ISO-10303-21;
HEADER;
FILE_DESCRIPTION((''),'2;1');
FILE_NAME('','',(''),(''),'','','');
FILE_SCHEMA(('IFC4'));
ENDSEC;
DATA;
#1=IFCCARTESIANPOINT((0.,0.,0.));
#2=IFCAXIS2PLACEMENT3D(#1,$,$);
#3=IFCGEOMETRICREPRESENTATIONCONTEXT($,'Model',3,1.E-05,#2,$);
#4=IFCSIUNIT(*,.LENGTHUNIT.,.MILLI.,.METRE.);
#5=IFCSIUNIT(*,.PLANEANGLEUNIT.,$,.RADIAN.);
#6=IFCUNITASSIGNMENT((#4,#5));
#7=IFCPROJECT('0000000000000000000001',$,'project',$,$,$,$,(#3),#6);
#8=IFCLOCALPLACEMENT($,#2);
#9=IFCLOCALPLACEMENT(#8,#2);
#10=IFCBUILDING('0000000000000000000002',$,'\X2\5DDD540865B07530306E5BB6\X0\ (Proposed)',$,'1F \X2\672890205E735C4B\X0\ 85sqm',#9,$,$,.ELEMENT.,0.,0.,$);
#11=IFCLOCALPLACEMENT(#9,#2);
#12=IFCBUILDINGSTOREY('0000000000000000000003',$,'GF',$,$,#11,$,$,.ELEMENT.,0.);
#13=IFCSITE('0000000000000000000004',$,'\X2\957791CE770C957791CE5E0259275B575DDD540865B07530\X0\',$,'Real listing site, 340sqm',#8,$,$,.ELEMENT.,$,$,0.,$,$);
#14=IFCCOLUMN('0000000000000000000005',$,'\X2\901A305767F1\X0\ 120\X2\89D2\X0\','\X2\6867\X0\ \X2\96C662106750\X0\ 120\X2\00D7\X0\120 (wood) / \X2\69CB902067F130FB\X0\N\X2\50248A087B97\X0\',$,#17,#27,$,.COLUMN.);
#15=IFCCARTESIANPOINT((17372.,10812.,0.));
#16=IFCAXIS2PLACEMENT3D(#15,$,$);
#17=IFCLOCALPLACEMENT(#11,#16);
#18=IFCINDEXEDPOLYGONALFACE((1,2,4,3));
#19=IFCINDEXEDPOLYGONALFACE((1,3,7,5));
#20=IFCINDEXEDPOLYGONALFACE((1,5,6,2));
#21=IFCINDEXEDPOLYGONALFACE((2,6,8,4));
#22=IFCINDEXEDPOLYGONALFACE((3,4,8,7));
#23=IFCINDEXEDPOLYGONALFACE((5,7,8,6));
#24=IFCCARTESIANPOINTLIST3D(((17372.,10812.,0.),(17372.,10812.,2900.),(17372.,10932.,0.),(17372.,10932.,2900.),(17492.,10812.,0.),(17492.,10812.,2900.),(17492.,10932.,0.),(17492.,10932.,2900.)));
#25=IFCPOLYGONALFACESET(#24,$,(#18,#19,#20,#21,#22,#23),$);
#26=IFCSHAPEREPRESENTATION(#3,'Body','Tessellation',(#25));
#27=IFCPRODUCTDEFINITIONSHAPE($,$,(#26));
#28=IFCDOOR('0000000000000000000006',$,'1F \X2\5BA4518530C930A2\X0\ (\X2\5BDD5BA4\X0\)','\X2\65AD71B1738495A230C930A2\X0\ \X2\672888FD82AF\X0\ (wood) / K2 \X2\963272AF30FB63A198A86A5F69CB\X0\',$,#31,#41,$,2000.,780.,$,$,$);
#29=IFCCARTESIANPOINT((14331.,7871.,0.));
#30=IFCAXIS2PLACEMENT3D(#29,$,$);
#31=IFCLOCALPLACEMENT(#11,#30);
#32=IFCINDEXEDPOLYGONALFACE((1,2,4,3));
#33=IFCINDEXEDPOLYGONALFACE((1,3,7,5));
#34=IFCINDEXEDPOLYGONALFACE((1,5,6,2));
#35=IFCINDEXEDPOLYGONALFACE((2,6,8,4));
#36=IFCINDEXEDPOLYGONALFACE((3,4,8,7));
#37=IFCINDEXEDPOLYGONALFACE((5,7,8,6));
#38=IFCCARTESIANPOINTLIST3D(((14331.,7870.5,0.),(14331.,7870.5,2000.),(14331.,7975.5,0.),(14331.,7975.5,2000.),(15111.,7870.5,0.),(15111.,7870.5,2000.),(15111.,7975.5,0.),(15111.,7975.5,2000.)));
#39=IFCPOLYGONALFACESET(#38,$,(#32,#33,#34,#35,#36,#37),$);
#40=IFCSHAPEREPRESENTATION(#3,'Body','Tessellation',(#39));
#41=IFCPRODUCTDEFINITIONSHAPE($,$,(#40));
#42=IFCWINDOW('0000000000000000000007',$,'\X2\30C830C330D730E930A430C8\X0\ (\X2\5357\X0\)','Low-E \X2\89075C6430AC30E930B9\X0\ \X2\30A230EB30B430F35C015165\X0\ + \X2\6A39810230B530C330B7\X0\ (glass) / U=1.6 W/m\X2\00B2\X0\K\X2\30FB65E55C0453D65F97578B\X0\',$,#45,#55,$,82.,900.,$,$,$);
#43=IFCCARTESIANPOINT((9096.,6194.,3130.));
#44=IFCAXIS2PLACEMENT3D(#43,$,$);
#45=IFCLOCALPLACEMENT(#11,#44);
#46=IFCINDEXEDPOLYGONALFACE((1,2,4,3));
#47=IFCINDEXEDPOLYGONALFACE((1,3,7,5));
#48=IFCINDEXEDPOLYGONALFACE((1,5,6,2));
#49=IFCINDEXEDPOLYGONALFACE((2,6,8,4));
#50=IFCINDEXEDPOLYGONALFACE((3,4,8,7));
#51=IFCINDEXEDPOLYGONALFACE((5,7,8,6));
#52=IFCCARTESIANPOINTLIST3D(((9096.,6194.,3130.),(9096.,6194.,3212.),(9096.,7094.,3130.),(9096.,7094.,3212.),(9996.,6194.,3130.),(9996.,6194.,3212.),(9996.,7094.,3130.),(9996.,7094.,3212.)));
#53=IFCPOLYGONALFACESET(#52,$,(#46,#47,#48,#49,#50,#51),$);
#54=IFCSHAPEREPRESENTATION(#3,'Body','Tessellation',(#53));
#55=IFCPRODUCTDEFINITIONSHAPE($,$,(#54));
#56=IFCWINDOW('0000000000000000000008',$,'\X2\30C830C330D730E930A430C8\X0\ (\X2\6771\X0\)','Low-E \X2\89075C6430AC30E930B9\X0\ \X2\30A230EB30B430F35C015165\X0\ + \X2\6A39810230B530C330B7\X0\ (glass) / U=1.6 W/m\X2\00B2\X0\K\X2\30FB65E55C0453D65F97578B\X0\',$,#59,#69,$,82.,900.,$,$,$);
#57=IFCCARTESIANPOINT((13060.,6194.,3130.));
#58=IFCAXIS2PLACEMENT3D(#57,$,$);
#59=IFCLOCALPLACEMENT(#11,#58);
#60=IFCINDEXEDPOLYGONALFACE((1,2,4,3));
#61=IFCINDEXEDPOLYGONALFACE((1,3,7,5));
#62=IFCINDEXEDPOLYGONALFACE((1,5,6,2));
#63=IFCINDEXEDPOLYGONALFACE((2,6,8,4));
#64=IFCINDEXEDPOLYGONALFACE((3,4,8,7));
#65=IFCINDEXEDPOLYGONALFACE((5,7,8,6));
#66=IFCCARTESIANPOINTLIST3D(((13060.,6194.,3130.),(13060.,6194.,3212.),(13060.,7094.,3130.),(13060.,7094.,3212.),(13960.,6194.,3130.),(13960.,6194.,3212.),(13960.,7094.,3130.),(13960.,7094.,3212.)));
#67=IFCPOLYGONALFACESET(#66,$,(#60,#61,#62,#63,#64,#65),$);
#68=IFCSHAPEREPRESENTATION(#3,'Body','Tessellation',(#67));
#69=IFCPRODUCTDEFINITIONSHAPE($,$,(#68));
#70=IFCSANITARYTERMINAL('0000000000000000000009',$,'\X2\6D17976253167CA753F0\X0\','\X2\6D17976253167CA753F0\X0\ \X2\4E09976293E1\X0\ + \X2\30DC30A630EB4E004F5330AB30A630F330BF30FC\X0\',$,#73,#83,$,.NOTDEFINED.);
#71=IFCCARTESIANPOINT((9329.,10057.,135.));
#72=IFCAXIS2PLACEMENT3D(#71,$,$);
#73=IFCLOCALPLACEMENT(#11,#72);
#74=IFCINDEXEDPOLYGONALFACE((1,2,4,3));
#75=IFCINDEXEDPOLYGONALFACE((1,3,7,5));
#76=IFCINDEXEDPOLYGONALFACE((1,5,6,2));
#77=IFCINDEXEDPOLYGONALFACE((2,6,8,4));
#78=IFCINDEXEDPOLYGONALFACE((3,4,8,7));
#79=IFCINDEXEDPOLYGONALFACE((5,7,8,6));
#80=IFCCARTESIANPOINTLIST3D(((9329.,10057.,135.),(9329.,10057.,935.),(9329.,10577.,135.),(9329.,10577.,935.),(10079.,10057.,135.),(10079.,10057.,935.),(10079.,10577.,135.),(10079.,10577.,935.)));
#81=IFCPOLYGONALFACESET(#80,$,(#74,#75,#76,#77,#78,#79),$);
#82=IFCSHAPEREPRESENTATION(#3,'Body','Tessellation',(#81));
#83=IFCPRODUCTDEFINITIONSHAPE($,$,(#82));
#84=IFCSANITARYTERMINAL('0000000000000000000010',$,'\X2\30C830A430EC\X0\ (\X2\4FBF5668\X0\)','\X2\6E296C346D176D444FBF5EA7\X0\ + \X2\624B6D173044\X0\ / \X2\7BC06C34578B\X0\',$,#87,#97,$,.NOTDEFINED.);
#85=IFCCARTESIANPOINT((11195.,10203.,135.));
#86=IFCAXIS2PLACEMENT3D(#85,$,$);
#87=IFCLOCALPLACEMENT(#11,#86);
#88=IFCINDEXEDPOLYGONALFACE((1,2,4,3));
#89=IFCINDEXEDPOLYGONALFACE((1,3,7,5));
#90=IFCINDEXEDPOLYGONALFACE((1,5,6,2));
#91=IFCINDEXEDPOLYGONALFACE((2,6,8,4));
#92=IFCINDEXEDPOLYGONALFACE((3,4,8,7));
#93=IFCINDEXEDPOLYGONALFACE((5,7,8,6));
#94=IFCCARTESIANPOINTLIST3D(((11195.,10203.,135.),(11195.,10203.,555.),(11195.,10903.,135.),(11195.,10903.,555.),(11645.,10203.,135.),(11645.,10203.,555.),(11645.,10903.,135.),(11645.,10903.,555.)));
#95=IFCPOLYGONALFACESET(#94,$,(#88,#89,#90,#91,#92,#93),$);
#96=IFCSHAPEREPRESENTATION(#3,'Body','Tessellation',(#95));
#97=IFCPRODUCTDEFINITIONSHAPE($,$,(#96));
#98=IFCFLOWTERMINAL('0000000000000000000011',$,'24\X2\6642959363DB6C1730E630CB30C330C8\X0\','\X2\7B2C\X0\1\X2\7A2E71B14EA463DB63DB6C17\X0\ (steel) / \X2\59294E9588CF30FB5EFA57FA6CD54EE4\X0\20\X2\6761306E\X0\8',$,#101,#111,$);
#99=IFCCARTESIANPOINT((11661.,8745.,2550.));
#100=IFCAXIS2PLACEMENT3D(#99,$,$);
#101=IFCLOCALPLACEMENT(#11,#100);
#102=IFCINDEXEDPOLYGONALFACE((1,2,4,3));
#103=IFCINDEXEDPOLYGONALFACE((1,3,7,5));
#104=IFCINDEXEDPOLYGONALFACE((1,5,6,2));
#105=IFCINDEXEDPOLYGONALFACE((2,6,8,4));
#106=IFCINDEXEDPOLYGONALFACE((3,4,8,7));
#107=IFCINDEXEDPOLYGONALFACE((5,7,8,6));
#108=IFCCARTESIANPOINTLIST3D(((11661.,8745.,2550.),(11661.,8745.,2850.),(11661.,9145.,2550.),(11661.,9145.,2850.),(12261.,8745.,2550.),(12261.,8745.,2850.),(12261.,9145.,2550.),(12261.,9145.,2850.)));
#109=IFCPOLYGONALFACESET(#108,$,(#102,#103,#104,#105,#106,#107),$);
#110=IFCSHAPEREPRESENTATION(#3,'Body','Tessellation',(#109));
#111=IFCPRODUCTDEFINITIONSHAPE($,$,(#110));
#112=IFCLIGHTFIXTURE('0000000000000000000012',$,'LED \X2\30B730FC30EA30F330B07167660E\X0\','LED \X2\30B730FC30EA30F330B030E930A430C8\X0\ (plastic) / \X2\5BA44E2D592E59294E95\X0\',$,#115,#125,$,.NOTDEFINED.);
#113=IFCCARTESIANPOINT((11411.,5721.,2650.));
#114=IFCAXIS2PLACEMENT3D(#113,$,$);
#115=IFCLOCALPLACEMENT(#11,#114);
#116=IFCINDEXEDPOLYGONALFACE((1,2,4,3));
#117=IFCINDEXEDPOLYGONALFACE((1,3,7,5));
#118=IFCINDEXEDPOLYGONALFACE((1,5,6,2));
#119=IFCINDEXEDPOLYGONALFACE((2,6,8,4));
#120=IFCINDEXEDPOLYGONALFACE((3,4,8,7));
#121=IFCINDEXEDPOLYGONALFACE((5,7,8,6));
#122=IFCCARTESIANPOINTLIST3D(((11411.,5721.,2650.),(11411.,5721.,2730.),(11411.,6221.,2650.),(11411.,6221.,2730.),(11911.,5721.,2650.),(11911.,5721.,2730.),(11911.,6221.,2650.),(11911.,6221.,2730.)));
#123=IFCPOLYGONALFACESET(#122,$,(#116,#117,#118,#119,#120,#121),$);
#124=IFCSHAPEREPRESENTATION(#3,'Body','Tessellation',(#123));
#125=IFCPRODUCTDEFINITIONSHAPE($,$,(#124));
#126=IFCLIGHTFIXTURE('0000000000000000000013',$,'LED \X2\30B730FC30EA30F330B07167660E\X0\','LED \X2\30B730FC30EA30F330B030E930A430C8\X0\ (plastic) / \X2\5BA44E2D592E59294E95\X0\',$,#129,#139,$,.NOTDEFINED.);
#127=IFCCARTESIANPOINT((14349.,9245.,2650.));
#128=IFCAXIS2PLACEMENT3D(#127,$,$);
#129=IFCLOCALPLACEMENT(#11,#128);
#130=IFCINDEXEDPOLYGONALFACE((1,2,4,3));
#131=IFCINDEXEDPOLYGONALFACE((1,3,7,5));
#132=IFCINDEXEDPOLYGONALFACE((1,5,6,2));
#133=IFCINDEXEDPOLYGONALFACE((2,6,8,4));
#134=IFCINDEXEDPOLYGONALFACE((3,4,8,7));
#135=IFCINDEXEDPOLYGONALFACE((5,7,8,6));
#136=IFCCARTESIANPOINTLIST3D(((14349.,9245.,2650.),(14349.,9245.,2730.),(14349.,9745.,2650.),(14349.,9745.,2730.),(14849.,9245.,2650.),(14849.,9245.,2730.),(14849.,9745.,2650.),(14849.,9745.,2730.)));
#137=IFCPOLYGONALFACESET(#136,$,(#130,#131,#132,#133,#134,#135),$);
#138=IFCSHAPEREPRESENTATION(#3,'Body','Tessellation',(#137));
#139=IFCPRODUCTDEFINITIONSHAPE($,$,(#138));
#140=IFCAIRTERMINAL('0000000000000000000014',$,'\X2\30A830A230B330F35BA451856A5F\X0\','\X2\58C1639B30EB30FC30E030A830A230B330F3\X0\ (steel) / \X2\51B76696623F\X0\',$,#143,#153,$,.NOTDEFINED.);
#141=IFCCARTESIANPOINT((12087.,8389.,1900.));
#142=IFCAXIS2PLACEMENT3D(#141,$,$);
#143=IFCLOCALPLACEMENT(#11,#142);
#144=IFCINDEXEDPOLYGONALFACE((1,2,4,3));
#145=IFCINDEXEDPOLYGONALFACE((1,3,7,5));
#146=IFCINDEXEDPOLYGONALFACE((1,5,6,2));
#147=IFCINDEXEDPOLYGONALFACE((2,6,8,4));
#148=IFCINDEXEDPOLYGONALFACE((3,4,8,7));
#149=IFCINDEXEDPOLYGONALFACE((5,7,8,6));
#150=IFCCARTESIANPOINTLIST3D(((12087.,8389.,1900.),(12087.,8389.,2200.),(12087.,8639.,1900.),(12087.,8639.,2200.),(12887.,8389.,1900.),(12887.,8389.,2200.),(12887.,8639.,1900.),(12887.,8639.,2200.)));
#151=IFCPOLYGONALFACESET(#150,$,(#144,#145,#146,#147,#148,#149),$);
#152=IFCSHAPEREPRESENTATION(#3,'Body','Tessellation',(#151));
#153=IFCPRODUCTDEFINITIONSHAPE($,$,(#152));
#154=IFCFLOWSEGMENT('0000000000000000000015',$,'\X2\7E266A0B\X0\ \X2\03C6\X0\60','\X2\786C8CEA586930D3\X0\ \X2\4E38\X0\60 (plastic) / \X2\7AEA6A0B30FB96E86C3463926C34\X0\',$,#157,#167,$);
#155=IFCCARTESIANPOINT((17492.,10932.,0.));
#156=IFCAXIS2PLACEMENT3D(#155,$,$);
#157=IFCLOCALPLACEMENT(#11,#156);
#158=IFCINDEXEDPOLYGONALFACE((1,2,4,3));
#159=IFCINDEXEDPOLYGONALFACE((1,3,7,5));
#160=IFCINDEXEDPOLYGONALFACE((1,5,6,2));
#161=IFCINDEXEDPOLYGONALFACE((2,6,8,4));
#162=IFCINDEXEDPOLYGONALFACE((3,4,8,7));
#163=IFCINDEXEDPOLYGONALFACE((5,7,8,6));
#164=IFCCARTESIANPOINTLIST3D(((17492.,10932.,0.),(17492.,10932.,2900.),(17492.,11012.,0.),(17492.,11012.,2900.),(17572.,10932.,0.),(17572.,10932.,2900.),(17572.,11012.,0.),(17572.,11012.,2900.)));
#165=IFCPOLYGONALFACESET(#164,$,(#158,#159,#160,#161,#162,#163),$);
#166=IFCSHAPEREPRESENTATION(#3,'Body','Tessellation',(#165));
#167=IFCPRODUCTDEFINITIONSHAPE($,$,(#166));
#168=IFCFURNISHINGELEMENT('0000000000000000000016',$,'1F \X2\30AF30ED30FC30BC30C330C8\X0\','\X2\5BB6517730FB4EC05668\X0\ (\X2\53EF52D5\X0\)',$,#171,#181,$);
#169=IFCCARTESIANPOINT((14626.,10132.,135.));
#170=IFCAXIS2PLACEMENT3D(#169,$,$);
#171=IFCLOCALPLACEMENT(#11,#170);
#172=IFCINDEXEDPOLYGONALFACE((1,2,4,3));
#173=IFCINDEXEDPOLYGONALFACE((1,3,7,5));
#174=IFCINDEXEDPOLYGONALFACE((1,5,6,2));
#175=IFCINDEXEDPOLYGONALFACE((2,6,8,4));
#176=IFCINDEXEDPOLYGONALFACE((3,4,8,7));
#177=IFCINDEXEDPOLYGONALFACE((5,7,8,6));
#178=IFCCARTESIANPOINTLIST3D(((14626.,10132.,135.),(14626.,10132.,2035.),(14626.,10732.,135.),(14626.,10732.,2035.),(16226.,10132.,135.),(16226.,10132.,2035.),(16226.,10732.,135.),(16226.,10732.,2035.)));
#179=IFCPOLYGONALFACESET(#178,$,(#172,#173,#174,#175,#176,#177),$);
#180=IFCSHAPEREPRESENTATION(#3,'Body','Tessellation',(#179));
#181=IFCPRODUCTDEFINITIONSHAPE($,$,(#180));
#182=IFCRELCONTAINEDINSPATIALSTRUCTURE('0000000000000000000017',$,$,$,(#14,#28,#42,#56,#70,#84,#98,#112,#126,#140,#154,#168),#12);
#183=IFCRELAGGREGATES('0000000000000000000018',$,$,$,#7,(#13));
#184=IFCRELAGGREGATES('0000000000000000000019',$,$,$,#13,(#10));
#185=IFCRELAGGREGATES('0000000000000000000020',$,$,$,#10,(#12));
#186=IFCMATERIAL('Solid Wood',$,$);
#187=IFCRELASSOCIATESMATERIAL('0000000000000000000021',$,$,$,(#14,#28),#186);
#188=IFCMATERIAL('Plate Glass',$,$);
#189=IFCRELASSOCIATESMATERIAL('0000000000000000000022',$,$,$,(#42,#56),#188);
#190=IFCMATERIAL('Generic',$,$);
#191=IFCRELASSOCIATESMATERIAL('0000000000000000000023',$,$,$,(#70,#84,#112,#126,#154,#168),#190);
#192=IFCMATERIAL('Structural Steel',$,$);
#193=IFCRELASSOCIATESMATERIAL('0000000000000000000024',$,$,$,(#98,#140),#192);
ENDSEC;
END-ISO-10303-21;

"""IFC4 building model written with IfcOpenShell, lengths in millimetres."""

from ifc_helpers import new_model, si_unit, frame, frame_2d, origin, place, context, project, spatial, rectangle, extrude, material, element, save


model = new_model("IFC4")

# Units and contexts
model_context = context("Model", 3, precision=1e-05, world=origin())
ifc_project = project(units=[si_unit("LENGTHUNIT", "METRE", prefix="MILLI"), si_unit("PLANEANGLEUNIT", "RADIAN")], contexts=[model_context])

# Site, building, storey
site_placement = place(None, origin())
site = spatial("IfcSite", under=ifc_project, at=site_placement, Name="長野県長野市大字川合新田", ObjectType="Real listing site, 340sqm", CompositionType="ELEMENT", RefElevation=0.0)
building_placement = place(site_placement, origin())
building = spatial("IfcBuilding", under=site, at=building_placement, Name="川合新田の家 (Proposed)", ObjectType="1F 木造平屋 85sqm", CompositionType="ELEMENT", ElevationOfRefHeight=0.0, ElevationOfTerrain=0.0)
storey_placement = place(building_placement, origin())
storey = spatial("IfcBuildingStorey", under=building, at=storey_placement, Name="GF", CompositionType="ELEMENT", Elevation=0.0)

# Column
ifc_material_1 = material(Name="Solid Wood")
column_1_placement = place(storey_placement, frame((17372.0, 10812.0, 0.0)))
element("IfcColumn", 1, at=column_1_placement, inside=storey, material=ifc_material_1, Name="通し柱 120角", Description="桧 集成材 120×120 (wood) / 構造柱・N値計算", PredefinedType="COLUMN", context=model_context, shape_type="SweptSolid", body=[
    extrude(rectangle(XDim=120.0, YDim=120.0, at=frame_2d((60.0, 60.0))), frame((17372.0, 10812.0, 0.0)), (0.0, 0.0, 1.0), 2900.0),
])

# Door
door_placement = place(storey_placement, frame((14331.0, 7871.0, 0.0)))
element("IfcDoor", 2, at=door_placement, inside=storey, material=ifc_material_1, Name="1F 室内ドア (寝室)", Description="断熱玄関ドア 木製芯 (wood) / K2 防犯・採風機構", OverallHeight=2000.0, OverallWidth=780.0, context=model_context, shape_type="SweptSolid", body=[
    extrude(rectangle(XDim=780.0, YDim=105.0, at=frame_2d((390.0, 52.0))), frame((14331.0, 7871.0, 0.0)), (0.0, 0.0, 1.0), 2000.0),
])

# Windows
ifc_material_2 = material(Name="Plate Glass")
window_1_placement = place(storey_placement, frame((9096.0, 6194.0, 3130.0)))
element("IfcWindow", 3, at=window_1_placement, inside=storey, material=ifc_material_2, Name="トップライト (南)", Description="Low-E 複層ガラス アルゴン封入 + 樹脂サッシ (glass) / U=1.6 W/m²K・日射取得型", OverallHeight=82.0, OverallWidth=900.0, context=model_context, shape_type="SweptSolid", body=[
    extrude(rectangle(XDim=900.0, YDim=900.0, at=frame_2d((450.0, 450.0))), frame((9096.0, 6194.0, 3130.0)), (0.0, 0.0, 1.0), 82.0),
])
window_2_placement = place(storey_placement, frame((13060.0, 6194.0, 3130.0)))
element("IfcWindow", 4, at=window_2_placement, inside=storey, material=ifc_material_2, Name="トップライト (東)", Description="Low-E 複層ガラス アルゴン封入 + 樹脂サッシ (glass) / U=1.6 W/m²K・日射取得型", OverallHeight=82.0, OverallWidth=900.0, context=model_context, shape_type="SweptSolid", body=[
    extrude(rectangle(XDim=900.0, YDim=900.0, at=frame_2d((450.0, 450.0))), frame((13060.0, 6194.0, 3130.0)), (0.0, 0.0, 1.0), 82.0),
])

# Sanitary terminals
ifc_material_3 = material(Name="Generic")
sanitary_terminal_1_placement = place(storey_placement, frame((9329.0, 10057.0, 135.0)))
element("IfcSanitaryTerminal", 5, at=sanitary_terminal_1_placement, inside=storey, material=ifc_material_3, Name="洗面化粧台", Description="洗面化粧台 三面鏡 + ボウル一体カウンター", PredefinedType="NOTDEFINED", context=model_context, shape_type="SweptSolid", body=[
    extrude(rectangle(XDim=750.0, YDim=520.0, at=frame_2d((375.0, 260.0))), frame((9329.0, 10057.0, 135.0)), (0.0, 0.0, 1.0), 800.0),
])
sanitary_terminal_2_placement = place(storey_placement, frame((11195.0, 10203.0, 135.0)))
element("IfcSanitaryTerminal", 6, at=sanitary_terminal_2_placement, inside=storey, material=ifc_material_3, Name="トイレ (便器)", Description="温水洗浄便座 + 手洗い / 節水型", PredefinedType="NOTDEFINED", context=model_context, shape_type="SweptSolid", body=[
    extrude(rectangle(XDim=450.0, YDim=700.0, at=frame_2d((225.0, 350.0))), frame((11195.0, 10203.0, 135.0)), (0.0, 0.0, 1.0), 420.0),
])

# Flow terminal
ifc_material_4 = material(Name="Structural Steel")
flow_terminal_placement = place(storey_placement, frame((11661.0, 8745.0, 2550.0)))
element("IfcFlowTerminal", 7, at=flow_terminal_placement, inside=storey, material=ifc_material_4, Name="24時間換気ユニット", Description="第1種熱交換換気 (steel) / 天井裏・建基法令20条の8", context=model_context, shape_type="SweptSolid", body=[
    extrude(rectangle(XDim=600.0, YDim=400.0, at=frame_2d((300.0, 200.0))), frame((11661.0, 8745.0, 2550.0)), (0.0, 0.0, 1.0), 300.0),
])

# Light fixtures
light_fixture_1_placement = place(storey_placement, frame((11411.0, 5721.0, 2650.0)))
element("IfcLightFixture", 8, at=light_fixture_1_placement, inside=storey, material=ifc_material_3, Name="LED シーリング照明", Description="LED シーリングライト (plastic) / 室中央天井", PredefinedType="NOTDEFINED", context=model_context, shape_type="SweptSolid", body=[
    extrude(rectangle(XDim=500.0, YDim=500.0, at=frame_2d((250.0, 250.0))), frame((11411.0, 5721.0, 2650.0)), (0.0, 0.0, 1.0), 80.0),
])
light_fixture_2_placement = place(storey_placement, frame((14349.0, 9245.0, 2650.0)))
element("IfcLightFixture", 9, at=light_fixture_2_placement, inside=storey, material=ifc_material_3, Name="LED シーリング照明", Description="LED シーリングライト (plastic) / 室中央天井", PredefinedType="NOTDEFINED", context=model_context, shape_type="SweptSolid", body=[
    extrude(rectangle(XDim=500.0, YDim=500.0, at=frame_2d((250.0, 250.0))), frame((14349.0, 9245.0, 2650.0)), (0.0, 0.0, 1.0), 80.0),
])

# Air terminal
air_terminal_placement = place(storey_placement, frame((12087.0, 8389.0, 1900.0)))
element("IfcAirTerminal", 10, at=air_terminal_placement, inside=storey, material=ifc_material_4, Name="エアコン室内機", Description="壁掛ルームエアコン (steel) / 冷暖房", PredefinedType="NOTDEFINED", context=model_context, shape_type="SweptSolid", body=[
    extrude(rectangle(XDim=800.0, YDim=250.0, at=frame_2d((400.0, 125.0))), frame((12087.0, 8389.0, 1900.0)), (0.0, 0.0, 1.0), 300.0),
])

# Flow segment
flow_segment_placement = place(storey_placement, frame((17492.0, 10932.0, 0.0)))
element("IfcFlowSegment", 11, at=flow_segment_placement, inside=storey, material=ifc_material_3, Name="縦樋 φ60", Description="硬質塩ビ 丸60 (plastic) / 竪樋・雨水排水", context=model_context, shape_type="SweptSolid", body=[
    extrude(rectangle(XDim=80.0, YDim=80.0, at=frame_2d((40.0, 40.0))), frame((17492.0, 10932.0, 0.0)), (0.0, 0.0, 1.0), 2900.0),
])

# Furnishing element
furnishing_placement = place(storey_placement, frame((14626.0, 10132.0, 135.0)))
element("IfcFurnishingElement", 12, at=furnishing_placement, inside=storey, material=ifc_material_3, Name="1F クローゼット", Description="家具・什器 (可動)", context=model_context, shape_type="SweptSolid", body=[
    extrude(rectangle(XDim=1600.0, YDim=600.0, at=frame_2d((800.0, 300.0))), frame((14626.0, 10132.0, 135.0)), (0.0, 0.0, 1.0), 1900.0),
])

save(model, "model.ifc")
